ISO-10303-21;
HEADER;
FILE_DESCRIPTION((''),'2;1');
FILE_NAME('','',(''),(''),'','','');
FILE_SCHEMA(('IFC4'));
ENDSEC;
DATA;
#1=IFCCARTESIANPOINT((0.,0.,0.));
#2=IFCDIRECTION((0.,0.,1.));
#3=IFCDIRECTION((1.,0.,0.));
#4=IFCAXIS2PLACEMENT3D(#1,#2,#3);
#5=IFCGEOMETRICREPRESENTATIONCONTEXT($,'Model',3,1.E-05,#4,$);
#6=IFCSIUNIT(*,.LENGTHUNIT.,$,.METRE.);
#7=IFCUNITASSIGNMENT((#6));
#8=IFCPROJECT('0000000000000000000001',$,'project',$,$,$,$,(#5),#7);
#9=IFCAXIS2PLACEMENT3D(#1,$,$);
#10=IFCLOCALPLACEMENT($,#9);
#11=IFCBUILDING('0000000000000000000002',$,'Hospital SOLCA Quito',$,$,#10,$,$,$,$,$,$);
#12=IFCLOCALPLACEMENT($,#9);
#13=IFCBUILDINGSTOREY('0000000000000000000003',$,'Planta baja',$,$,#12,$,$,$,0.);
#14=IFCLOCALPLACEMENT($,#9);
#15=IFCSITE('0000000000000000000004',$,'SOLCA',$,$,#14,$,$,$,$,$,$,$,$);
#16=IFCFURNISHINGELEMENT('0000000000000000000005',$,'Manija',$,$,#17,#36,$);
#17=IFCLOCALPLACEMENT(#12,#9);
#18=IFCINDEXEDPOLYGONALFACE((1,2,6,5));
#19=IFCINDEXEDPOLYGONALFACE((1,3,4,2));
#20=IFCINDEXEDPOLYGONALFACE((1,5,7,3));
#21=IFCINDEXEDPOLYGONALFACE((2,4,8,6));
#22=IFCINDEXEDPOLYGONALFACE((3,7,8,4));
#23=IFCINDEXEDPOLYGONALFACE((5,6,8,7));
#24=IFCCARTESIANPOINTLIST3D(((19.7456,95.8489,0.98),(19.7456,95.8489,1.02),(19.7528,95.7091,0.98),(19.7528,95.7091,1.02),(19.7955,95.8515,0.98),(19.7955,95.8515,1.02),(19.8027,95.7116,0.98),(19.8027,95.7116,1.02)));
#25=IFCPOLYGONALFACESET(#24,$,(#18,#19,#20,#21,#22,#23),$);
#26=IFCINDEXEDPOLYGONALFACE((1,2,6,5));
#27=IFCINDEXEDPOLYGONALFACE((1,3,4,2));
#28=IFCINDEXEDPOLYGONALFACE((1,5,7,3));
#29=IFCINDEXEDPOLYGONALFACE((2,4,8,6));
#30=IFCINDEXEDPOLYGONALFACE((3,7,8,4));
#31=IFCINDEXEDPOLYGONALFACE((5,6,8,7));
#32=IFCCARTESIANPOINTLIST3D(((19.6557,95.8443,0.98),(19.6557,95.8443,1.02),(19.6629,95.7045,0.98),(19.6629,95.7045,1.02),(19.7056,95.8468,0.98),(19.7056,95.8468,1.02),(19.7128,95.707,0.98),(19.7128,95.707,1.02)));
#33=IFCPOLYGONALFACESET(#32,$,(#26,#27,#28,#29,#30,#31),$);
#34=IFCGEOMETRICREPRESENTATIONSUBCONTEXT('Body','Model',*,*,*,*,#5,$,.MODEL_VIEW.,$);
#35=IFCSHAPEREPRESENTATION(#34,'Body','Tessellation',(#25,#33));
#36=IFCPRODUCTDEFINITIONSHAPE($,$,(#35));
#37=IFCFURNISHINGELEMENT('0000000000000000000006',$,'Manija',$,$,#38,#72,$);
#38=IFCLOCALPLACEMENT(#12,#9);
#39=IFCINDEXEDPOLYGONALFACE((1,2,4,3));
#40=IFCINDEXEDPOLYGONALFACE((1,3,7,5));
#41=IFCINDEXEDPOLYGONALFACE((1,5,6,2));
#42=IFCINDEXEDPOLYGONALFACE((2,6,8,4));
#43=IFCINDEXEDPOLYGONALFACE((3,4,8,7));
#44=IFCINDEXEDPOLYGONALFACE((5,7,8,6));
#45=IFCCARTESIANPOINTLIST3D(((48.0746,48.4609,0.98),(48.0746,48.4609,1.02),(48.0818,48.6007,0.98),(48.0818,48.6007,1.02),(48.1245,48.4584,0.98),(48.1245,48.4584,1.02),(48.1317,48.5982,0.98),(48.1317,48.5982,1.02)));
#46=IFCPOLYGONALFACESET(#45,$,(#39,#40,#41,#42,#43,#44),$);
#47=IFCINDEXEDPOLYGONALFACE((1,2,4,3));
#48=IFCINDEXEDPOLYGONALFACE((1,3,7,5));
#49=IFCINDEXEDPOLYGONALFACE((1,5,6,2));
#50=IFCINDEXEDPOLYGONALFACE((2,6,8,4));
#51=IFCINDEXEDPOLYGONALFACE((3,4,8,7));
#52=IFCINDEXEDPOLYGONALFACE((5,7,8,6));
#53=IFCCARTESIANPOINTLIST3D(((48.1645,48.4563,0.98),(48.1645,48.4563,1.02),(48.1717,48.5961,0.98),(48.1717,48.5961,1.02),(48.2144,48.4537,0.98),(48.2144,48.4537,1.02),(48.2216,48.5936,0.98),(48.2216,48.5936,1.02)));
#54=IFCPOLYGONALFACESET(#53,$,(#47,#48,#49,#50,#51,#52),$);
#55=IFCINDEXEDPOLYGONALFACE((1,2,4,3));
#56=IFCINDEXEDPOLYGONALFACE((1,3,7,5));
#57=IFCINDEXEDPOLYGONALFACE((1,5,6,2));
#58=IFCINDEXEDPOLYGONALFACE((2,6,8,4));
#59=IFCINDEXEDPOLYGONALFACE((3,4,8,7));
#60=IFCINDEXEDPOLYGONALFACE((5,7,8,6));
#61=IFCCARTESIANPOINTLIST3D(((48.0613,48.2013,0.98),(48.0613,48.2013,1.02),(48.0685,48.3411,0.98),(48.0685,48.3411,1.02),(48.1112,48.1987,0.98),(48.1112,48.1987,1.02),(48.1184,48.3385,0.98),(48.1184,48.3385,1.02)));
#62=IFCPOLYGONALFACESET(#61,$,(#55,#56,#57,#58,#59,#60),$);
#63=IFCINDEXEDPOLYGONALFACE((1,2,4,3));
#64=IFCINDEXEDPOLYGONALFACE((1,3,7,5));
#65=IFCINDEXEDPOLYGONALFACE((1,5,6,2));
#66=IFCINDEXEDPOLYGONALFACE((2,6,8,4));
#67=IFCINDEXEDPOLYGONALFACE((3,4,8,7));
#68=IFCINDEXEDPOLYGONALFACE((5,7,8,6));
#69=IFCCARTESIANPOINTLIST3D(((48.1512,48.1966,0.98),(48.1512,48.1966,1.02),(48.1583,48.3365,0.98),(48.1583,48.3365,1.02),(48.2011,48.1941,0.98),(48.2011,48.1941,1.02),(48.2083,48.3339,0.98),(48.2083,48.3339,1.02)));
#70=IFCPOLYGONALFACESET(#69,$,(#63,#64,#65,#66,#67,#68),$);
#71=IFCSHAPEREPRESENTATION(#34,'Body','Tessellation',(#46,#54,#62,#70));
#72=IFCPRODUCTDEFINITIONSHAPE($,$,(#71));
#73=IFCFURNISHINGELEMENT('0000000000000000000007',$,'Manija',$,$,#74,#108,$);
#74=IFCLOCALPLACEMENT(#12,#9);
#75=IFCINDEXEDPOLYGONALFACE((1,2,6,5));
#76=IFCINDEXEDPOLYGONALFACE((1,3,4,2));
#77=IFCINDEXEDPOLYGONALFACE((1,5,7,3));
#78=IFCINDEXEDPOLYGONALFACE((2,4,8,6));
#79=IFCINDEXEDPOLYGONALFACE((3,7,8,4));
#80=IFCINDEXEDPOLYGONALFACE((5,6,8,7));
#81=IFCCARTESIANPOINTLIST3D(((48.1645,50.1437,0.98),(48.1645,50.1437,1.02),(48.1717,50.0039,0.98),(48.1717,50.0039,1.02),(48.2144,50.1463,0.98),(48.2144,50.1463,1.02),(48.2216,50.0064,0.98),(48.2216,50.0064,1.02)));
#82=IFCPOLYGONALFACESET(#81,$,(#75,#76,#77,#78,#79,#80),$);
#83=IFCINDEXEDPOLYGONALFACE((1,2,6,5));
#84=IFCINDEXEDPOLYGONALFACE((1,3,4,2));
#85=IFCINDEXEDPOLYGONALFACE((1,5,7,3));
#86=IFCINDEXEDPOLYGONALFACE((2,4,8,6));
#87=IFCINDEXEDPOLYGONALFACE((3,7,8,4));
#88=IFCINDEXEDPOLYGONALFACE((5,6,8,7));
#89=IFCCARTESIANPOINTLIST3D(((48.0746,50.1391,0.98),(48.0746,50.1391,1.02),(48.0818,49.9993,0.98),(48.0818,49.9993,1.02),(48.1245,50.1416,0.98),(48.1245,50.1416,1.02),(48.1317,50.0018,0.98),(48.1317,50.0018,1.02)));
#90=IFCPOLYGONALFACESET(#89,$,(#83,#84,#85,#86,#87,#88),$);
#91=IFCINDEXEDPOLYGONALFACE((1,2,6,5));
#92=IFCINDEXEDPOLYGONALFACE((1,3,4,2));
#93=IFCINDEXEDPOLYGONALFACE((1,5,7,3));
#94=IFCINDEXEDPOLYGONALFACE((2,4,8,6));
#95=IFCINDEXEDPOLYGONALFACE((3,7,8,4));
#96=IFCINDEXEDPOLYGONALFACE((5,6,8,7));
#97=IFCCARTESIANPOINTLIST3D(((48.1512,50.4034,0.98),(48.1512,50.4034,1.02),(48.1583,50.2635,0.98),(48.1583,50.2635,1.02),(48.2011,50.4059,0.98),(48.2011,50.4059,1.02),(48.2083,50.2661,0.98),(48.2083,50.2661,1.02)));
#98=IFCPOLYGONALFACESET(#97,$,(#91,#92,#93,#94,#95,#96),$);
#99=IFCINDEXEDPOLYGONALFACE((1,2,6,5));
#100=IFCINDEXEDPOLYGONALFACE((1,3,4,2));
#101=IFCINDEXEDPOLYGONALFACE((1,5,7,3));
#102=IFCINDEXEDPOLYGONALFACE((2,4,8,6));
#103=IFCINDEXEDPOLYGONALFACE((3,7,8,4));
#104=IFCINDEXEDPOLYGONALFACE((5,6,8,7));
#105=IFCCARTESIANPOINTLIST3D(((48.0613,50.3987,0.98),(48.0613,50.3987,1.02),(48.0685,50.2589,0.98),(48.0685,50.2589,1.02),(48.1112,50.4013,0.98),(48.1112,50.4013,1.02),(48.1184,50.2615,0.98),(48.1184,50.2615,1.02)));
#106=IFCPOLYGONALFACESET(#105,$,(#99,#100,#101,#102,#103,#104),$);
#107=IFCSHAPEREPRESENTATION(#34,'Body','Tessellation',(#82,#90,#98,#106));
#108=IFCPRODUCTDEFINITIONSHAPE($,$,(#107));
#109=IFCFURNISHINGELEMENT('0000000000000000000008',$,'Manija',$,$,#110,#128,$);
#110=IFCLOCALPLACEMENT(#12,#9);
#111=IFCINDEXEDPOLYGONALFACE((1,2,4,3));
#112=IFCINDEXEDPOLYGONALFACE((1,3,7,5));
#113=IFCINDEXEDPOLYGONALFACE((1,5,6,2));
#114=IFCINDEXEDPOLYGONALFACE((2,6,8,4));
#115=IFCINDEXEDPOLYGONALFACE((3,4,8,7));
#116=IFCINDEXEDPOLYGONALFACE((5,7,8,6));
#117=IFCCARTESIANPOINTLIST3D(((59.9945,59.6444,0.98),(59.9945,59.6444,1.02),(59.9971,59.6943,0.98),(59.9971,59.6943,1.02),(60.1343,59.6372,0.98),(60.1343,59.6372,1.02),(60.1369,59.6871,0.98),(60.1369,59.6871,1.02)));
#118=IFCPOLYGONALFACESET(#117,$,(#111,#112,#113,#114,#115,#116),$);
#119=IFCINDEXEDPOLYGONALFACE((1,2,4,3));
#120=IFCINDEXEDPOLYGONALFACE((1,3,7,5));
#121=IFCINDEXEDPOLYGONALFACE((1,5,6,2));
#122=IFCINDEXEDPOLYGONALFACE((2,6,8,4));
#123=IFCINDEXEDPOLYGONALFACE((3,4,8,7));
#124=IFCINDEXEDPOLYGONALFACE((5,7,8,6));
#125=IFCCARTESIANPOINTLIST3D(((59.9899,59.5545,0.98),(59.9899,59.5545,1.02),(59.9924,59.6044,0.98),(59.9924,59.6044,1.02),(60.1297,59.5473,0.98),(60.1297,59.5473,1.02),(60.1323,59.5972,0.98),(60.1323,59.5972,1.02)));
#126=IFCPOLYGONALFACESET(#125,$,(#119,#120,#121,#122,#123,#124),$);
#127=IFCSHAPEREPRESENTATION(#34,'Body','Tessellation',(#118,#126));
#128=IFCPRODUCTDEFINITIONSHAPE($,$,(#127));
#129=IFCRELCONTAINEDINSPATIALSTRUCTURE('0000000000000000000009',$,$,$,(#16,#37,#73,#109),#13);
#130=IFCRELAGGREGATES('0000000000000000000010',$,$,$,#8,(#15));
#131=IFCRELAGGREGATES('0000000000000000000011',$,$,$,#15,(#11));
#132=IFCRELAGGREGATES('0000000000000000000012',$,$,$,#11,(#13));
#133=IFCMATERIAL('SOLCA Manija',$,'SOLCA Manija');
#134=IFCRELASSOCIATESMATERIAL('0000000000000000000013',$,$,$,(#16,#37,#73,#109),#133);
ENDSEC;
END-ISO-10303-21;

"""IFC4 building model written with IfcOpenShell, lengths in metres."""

from ifc_helpers import new_model, si_unit, frame, origin, origin_with_axes, place, context, subcontext, project, spatial, polyline, outline, extrude, material, element, save


model = new_model("IFC4")

# Units and contexts
model_context = context("Model", 3, precision=1e-05, world=origin_with_axes())
body_context = subcontext(model_context, "Body", "Model", "MODEL_VIEW")
ifc_project = project(units=[si_unit("LENGTHUNIT", "METRE")], contexts=[model_context])

# Site, building, storey
site_placement = place(None, origin())
site = spatial("IfcSite", under=ifc_project, at=site_placement, Name="SOLCA")
building_placement = place(None, origin())
building = spatial("IfcBuilding", under=site, at=building_placement, Name="Hospital SOLCA Quito")
storey_placement = place(None, origin())
storey = spatial("IfcBuildingStorey", under=building, at=storey_placement, Name="Planta baja", Elevation=0.0)

# Furnishing elements
ifc_material_1 = material(Name="SOLCA Manija", Category="SOLCA Manija")
furnishing_1_placement = place(storey_placement, origin_with_axes())
element("IfcFurnishingElement", 1, at=furnishing_1_placement, inside=storey, material=ifc_material_1, Name="Manija", context=body_context, shape_type="SweptSolid", body=[
    extrude(outline(polyline([(19.8027, 95.7116), (19.7955, 95.8515), (19.7456, 95.8489), (19.7528, 95.7091), (19.8027, 95.7116)])), frame((0.0, 0.0, 0.98), z_axis=(0.0, 0.0, 1.0), x_axis=(1.0, 0.0, 0.0)), (0.0, 0.0, 1.0), 0.04),
    extrude(outline(polyline([(19.7128, 95.707), (19.7056, 95.8468), (19.6557, 95.8443), (19.6629, 95.7045), (19.7128, 95.707)])), frame((0.0, 0.0, 0.98), z_axis=(0.0, 0.0, 1.0), x_axis=(1.0, 0.0, 0.0)), (0.0, 0.0, 1.0), 0.04),
])
furnishing_2_placement = place(storey_placement, origin_with_axes())
element("IfcFurnishingElement", 2, at=furnishing_2_placement, inside=storey, material=ifc_material_1, Name="Manija", context=body_context, shape_type="SweptSolid", body=[
    extrude(outline(polyline([(48.0746, 48.4609), (48.0818, 48.6007), (48.1317, 48.5982), (48.1245, 48.4584), (48.0746, 48.4609)])), frame((0.0, 0.0, 0.98), z_axis=(0.0, 0.0, 1.0), x_axis=(1.0, 0.0, 0.0)), (0.0, 0.0, 1.0), 0.04),
    extrude(outline(polyline([(48.1645, 48.4563), (48.1717, 48.5961), (48.2216, 48.5936), (48.2144, 48.4537), (48.1645, 48.4563)])), frame((0.0, 0.0, 0.98), z_axis=(0.0, 0.0, 1.0), x_axis=(1.0, 0.0, 0.0)), (0.0, 0.0, 1.0), 0.04),
    extrude(outline(polyline([(48.0685, 48.3411), (48.0613, 48.2013), (48.1112, 48.1987), (48.1184, 48.3385), (48.0685, 48.3411)])), frame((0.0, 0.0, 0.98), z_axis=(0.0, 0.0, 1.0), x_axis=(1.0, 0.0, 0.0)), (0.0, 0.0, 1.0), 0.04),
    extrude(outline(polyline([(48.1583, 48.3365), (48.1512, 48.1966), (48.2011, 48.1941), (48.2083, 48.3339), (48.1583, 48.3365)])), frame((0.0, 0.0, 0.98), z_axis=(0.0, 0.0, 1.0), x_axis=(1.0, 0.0, 0.0)), (0.0, 0.0, 1.0), 0.04),
])
furnishing_3_placement = place(storey_placement, origin_with_axes())
element("IfcFurnishingElement", 3, at=furnishing_3_placement, inside=storey, material=ifc_material_1, Name="Manija", context=body_context, shape_type="SweptSolid", body=[
    extrude(outline(polyline([(48.2144, 50.1463), (48.2216, 50.0064), (48.1717, 50.0039), (48.1645, 50.1437), (48.2144, 50.1463)])), frame((0.0, 0.0, 0.98), z_axis=(0.0, 0.0, 1.0), x_axis=(1.0, 0.0, 0.0)), (0.0, 0.0, 1.0), 0.04),
    extrude(outline(polyline([(48.1245, 50.1416), (48.1317, 50.0018), (48.0818, 49.9993), (48.0746, 50.1391), (48.1245, 50.1416)])), frame((0.0, 0.0, 0.98), z_axis=(0.0, 0.0, 1.0), x_axis=(1.0, 0.0, 0.0)), (0.0, 0.0, 1.0), 0.04),
    extrude(outline(polyline([(48.2083, 50.2661), (48.2011, 50.4059), (48.1512, 50.4034), (48.1583, 50.2635), (48.2083, 50.2661)])), frame((0.0, 0.0, 0.98), z_axis=(0.0, 0.0, 1.0), x_axis=(1.0, 0.0, 0.0)), (0.0, 0.0, 1.0), 0.04),
    extrude(outline(polyline([(48.1184, 50.2615), (48.1112, 50.4013), (48.0613, 50.3987), (48.0685, 50.2589), (48.1184, 50.2615)])), frame((0.0, 0.0, 0.98), z_axis=(0.0, 0.0, 1.0), x_axis=(1.0, 0.0, 0.0)), (0.0, 0.0, 1.0), 0.04),
])
furnishing_4_placement = place(storey_placement, origin_with_axes())
element("IfcFurnishingElement", 4, at=furnishing_4_placement, inside=storey, material=ifc_material_1, Name="Manija", context=body_context, shape_type="SweptSolid", body=[
    extrude(outline(polyline([(60.1369, 59.6871), (59.9971, 59.6943), (59.9945, 59.6444), (60.1343, 59.6372), (60.1369, 59.6871)])), frame((0.0, 0.0, 0.98), z_axis=(0.0, 0.0, 1.0), x_axis=(1.0, 0.0, 0.0)), (0.0, 0.0, 1.0), 0.04),
    extrude(outline(polyline([(60.1323, 59.5972), (59.9924, 59.6044), (59.9899, 59.5545), (60.1297, 59.5473), (60.1323, 59.5972)])), frame((0.0, 0.0, 0.98), z_axis=(0.0, 0.0, 1.0), x_axis=(1.0, 0.0, 0.0)), (0.0, 0.0, 1.0), 0.04),
])

save(model, "model.ifc")
